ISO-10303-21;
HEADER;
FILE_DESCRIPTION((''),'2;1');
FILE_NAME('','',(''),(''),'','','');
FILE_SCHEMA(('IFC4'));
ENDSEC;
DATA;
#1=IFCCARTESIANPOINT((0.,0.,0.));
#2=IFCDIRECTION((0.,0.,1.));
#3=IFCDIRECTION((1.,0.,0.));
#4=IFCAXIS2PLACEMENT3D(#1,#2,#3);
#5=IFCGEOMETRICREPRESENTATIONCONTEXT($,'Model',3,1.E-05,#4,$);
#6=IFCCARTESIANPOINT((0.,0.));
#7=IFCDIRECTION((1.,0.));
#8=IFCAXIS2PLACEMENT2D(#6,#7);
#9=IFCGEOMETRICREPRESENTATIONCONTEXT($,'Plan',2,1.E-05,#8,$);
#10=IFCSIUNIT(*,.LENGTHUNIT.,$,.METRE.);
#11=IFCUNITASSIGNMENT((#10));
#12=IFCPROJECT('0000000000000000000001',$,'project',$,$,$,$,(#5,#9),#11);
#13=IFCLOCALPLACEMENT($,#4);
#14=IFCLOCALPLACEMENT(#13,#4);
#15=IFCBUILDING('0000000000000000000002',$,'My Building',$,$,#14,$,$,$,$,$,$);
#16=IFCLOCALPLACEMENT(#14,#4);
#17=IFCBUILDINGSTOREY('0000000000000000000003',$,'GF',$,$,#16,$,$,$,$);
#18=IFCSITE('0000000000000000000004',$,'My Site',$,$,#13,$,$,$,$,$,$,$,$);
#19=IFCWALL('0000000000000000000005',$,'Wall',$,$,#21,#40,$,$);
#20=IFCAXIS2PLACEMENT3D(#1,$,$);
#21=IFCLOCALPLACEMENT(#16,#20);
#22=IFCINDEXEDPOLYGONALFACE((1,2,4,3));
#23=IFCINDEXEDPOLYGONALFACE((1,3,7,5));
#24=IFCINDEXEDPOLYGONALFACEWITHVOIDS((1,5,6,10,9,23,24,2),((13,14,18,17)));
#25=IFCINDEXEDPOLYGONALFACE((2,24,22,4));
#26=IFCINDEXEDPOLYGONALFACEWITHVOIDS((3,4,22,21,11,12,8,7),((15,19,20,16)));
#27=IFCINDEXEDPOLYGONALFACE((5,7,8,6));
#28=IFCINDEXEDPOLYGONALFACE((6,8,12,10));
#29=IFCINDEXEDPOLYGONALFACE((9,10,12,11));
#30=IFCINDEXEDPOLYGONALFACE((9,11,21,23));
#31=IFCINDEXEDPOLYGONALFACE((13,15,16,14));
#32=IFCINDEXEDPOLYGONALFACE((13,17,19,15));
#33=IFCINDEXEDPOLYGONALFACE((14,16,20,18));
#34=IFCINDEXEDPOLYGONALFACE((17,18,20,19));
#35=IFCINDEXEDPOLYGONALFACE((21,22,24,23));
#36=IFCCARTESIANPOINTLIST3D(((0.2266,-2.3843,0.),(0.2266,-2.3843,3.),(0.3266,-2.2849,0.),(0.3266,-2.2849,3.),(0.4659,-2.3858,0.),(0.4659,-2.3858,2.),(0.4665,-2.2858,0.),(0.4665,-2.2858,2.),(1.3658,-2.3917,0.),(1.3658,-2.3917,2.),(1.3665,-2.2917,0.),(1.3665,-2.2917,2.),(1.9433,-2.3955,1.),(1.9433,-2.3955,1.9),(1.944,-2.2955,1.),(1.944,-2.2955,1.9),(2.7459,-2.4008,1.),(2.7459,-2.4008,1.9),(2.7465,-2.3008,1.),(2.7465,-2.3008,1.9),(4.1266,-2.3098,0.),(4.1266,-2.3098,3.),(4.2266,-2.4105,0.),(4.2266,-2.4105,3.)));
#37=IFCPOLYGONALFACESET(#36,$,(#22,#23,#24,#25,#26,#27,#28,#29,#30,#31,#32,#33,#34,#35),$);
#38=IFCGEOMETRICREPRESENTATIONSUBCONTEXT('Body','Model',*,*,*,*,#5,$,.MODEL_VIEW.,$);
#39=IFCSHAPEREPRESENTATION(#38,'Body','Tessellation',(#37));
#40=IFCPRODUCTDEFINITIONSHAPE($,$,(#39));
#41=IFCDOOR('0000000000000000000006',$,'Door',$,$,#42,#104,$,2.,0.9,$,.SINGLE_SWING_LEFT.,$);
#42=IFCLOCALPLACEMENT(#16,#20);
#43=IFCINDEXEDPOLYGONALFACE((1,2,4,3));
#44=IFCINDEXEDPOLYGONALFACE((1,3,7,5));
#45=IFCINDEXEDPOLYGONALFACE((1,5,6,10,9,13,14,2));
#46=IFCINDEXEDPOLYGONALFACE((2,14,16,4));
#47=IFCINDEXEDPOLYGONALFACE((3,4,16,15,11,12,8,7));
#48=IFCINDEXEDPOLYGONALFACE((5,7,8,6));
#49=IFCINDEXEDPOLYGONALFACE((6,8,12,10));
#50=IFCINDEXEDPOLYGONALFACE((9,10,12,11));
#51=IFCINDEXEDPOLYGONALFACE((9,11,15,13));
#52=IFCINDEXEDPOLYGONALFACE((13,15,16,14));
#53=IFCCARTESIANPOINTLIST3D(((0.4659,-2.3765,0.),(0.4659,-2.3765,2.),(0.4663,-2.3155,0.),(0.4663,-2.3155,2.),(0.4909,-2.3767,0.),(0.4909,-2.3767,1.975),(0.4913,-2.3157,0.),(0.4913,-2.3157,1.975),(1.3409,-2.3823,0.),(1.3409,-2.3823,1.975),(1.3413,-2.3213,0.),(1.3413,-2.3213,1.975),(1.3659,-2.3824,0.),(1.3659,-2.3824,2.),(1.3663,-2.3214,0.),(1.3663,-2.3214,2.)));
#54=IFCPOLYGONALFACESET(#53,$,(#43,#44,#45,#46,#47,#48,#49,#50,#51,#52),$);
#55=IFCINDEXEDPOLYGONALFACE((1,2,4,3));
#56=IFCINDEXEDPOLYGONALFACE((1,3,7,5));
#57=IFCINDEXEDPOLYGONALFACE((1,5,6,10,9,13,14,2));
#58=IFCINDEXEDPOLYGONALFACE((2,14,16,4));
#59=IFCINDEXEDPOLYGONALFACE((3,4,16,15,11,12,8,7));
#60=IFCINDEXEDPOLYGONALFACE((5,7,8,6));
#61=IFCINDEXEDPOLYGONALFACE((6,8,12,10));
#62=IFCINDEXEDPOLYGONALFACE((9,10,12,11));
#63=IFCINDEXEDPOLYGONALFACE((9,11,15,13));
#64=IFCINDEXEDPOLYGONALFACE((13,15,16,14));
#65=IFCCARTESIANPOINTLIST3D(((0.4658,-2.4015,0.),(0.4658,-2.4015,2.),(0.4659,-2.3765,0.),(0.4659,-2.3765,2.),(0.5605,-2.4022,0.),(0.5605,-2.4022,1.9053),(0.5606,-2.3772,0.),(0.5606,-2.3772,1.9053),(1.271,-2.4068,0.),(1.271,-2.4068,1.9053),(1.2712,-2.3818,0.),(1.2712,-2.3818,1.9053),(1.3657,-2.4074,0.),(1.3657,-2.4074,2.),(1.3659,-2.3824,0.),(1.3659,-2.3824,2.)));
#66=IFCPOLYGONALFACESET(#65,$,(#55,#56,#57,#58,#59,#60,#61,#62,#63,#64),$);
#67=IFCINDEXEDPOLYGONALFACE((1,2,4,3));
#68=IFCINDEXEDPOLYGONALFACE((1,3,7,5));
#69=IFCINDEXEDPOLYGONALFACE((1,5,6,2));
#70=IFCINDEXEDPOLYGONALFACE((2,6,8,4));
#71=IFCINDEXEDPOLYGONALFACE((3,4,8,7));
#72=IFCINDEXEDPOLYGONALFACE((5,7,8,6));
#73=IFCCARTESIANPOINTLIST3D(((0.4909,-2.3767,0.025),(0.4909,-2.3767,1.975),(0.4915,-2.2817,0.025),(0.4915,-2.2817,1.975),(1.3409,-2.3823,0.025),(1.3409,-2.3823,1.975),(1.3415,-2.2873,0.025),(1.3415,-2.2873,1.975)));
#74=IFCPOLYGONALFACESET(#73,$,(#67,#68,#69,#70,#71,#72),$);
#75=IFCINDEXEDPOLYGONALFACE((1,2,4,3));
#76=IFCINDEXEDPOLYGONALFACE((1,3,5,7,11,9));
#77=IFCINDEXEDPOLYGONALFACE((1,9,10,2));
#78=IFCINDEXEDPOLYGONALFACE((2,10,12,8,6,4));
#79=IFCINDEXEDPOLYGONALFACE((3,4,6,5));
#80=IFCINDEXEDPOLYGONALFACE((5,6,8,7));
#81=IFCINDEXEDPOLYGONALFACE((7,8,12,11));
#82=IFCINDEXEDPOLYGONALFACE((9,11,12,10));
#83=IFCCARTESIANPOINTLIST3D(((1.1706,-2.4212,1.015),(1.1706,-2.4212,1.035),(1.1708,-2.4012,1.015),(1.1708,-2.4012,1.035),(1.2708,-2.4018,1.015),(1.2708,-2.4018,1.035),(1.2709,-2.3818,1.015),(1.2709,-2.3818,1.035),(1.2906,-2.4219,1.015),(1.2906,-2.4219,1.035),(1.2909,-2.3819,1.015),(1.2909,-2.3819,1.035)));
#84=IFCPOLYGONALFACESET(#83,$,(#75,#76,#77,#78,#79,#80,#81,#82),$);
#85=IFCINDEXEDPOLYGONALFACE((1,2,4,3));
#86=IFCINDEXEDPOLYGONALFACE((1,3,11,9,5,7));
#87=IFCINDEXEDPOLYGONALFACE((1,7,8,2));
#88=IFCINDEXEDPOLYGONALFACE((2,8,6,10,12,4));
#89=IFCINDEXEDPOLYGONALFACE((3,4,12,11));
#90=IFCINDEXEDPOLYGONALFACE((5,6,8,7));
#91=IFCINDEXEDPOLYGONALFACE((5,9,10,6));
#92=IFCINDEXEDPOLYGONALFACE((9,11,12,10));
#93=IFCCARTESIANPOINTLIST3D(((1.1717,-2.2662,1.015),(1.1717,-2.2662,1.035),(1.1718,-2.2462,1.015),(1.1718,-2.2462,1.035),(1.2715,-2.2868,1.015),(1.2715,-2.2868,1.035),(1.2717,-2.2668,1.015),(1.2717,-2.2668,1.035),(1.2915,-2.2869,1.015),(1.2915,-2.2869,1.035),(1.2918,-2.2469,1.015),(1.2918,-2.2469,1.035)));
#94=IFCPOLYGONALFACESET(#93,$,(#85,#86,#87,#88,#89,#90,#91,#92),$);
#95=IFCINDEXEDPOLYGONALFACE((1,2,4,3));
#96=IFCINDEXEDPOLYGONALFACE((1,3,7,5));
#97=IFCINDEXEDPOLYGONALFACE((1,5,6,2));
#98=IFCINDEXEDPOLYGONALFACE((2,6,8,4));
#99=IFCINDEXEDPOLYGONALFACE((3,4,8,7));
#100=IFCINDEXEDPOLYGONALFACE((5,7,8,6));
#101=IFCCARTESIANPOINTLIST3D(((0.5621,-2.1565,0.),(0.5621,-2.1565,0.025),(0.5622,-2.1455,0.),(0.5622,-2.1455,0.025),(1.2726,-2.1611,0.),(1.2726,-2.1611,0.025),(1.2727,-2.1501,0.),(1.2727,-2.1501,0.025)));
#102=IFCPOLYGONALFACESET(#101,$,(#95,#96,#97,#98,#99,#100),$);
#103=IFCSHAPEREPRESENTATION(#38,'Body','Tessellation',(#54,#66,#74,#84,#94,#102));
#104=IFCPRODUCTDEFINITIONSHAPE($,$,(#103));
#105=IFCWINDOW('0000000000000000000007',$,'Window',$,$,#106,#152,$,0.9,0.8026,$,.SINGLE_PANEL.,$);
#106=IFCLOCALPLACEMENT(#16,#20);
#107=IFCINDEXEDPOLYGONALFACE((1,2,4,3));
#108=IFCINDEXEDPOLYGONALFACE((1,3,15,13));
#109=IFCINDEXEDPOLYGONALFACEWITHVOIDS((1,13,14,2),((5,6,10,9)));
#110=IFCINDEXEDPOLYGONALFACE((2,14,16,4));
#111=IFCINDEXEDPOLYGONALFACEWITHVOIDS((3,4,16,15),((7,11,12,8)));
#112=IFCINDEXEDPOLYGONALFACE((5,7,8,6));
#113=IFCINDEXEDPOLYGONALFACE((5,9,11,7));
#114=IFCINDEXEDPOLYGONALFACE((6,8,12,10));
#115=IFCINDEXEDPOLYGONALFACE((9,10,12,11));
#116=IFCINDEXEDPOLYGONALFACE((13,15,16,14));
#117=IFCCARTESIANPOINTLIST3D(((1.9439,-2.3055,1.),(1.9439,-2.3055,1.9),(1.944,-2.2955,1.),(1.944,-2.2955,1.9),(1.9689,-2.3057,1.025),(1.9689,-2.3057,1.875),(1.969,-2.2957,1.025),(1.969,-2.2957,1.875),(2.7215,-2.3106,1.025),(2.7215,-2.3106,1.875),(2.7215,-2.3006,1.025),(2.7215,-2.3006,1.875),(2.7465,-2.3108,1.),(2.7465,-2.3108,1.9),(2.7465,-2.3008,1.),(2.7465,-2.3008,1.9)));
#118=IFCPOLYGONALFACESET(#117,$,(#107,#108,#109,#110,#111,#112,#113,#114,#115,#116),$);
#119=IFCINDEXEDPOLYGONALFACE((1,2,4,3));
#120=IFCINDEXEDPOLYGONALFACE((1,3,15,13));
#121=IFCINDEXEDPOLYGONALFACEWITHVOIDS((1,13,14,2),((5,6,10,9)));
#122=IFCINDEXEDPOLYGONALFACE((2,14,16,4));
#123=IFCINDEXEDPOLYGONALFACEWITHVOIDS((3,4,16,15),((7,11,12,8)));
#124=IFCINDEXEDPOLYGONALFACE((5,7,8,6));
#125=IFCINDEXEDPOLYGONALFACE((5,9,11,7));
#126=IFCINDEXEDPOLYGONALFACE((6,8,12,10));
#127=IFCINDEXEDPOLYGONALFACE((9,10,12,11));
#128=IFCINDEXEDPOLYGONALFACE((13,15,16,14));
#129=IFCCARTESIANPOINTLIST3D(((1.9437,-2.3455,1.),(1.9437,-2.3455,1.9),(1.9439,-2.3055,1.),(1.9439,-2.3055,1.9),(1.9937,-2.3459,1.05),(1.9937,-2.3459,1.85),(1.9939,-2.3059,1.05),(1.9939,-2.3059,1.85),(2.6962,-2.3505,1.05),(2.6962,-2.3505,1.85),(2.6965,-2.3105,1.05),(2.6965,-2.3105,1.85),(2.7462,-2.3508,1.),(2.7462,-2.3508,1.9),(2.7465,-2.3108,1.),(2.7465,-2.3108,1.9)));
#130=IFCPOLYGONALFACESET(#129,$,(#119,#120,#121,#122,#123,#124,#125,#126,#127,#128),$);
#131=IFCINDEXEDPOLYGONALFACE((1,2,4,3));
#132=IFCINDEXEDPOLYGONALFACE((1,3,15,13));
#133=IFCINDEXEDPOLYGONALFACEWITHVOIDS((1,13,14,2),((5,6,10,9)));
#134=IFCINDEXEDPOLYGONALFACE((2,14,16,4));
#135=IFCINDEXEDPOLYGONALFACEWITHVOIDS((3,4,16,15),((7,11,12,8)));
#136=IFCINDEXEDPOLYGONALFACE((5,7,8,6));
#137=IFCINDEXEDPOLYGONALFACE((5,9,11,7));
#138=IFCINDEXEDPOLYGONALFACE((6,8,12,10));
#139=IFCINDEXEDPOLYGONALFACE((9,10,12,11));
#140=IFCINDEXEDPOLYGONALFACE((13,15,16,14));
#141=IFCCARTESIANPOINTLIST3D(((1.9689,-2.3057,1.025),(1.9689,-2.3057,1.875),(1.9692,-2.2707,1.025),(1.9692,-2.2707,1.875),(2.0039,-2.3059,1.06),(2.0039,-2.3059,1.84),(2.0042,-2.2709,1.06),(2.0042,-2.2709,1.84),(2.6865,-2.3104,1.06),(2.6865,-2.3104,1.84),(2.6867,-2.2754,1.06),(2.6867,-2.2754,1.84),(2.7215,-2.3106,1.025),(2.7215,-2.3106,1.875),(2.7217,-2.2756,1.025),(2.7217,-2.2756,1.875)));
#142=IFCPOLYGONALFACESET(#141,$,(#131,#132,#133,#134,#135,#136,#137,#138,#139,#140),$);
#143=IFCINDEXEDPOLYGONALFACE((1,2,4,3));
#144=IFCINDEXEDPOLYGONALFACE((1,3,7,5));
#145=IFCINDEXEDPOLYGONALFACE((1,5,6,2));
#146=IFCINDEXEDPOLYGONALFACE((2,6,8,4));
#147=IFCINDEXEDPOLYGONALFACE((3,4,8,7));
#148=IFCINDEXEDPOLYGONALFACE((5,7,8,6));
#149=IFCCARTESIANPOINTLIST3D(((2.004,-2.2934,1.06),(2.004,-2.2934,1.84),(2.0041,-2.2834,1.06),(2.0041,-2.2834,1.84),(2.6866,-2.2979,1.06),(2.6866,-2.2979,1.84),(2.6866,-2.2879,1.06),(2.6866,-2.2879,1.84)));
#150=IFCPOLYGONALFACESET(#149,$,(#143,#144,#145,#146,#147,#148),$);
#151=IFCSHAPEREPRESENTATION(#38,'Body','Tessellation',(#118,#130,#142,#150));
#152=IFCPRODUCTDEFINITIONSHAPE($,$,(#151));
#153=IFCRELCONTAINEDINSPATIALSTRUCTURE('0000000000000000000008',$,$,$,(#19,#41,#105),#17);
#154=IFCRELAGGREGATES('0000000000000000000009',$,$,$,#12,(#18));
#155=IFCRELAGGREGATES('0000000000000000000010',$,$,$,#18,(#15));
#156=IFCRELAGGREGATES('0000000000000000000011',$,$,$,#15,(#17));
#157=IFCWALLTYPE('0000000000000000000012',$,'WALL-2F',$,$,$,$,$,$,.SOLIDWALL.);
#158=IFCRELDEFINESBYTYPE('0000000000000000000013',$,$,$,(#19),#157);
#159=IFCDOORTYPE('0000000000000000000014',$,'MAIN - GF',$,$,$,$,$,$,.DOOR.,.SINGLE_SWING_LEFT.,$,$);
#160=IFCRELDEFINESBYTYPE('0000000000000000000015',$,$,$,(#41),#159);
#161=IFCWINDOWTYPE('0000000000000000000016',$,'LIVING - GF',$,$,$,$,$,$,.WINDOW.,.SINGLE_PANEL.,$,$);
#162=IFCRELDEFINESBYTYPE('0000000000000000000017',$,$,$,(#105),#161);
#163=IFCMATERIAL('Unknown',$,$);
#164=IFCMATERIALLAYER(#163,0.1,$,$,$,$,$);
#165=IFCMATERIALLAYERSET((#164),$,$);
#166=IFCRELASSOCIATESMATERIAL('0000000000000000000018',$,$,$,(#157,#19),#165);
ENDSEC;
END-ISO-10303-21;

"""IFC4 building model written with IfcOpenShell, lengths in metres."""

from ifc_helpers import new_model, entity, si_unit, frame, origin_with_axes, origin_2d_with_axis, place, context, subcontext, project, spatial, line, indexed_curve, outline, extrude, shape, source, transform, mapped, material, layer, layer_set, layer_usage, type_object, type_shapes, element, fill, save


model = new_model("IFC4")

# Units and contexts
model_context = context("Model", 3, precision=1e-05, world=origin_with_axes())
plan_context = context("Plan", 2, precision=1e-05, world=origin_2d_with_axis())
body_context_1 = subcontext(model_context, "Body", "Model", "MODEL_VIEW")
body_context_2 = subcontext(plan_context, "Body", "Plan", "PLAN_VIEW")
ifc_project = project(units=[si_unit("LENGTHUNIT", "METRE")], contexts=[model_context, plan_context])

# Site, building, storey
site_placement = place(None, origin_with_axes())
site = spatial("IfcSite", under=ifc_project, at=site_placement, Name="My Site")
building_placement = place(site_placement, origin_with_axes())
building = spatial("IfcBuilding", under=site, at=building_placement, Name="My Building")
storey_placement = place(building_placement, origin_with_axes())
storey = spatial("IfcBuildingStorey", under=building, at=storey_placement, Name="GF")

# Shared definitions
ifc_material_1 = material(Name="Unknown")

# Shared definitions
ifc_layer_1 = layer(ifc_material_1, 0.1)
ifc_layer_set_1 = layer_set([ifc_layer_1])
wall_type_1 = type_object("IfcWallType", Name="WALL-2F", PredefinedType="SOLIDWALL", material=ifc_layer_set_1)

# Wall, openings, door, window
ifc_layer_usage_1 = layer_usage(ifc_layer_set_1, "AXIS2", "POSITIVE", 0.0)
wall_1_placement = place(storey_placement, frame((0.2266, -2.3843, 0.0), z_axis=(0.0, 0.0, 1.0), x_axis=(0.999979, -0.006552, 0.0)))
wall_1 = element("IfcWall", 1, at=wall_1_placement, inside=storey, type_object=wall_type_1, material=ifc_layer_usage_1, Name="Wall", context=body_context_1, shape_type="SweptSolid", body=[
    extrude(outline(indexed_curve([(0.0, 0.0), (0.0993, 0.1), (3.8994, 0.1), (4.0001, 0.0)], segments=[line(1, 2, 3, 4, 1)])), origin_with_axes(), (0.0, 0.0, 1.0), 3.0),
])
shared_shape_1 = source(origin_with_axes(), body_context_1, "Body", "SweptSolid", [
    extrude(outline(indexed_curve([(0.0, 0.0), (0.9, 0.0), (0.9, 2.0), (0.0, 2.0)], segments=[line(1, 2, 3, 4, 1)])), frame((0.0, -0.6, 0.0), z_axis=(0.0, -1.0, 0.0), x_axis=(1.0, 0.0, 0.0)), (0.0, 0.0, -1.0), 1.2),
])
opening_1_placement = place(wall_1_placement, frame((0.2393, 0.0, 0.0), z_axis=(0.0, 0.0, 1.0), x_axis=(1.0, 0.0, 0.0)))
opening_1 = element("IfcOpeningElement", 2, at=opening_1_placement, cuts=wall_1, PredefinedType="OPENING", context=body_context_1, shape_type="MappedRepresentation", body=[
    mapped(shared_shape_1, transform((0.0, 0.0, 0.0), x_axis=(1.0, 0.0, 0.0), y_axis=(0.0, 1.0, 0.0), z_axis=(0.0, 0.0, 1.0), scale=1.0)),
])
shared_shape_2 = source(origin_with_axes(), body_context_1, "Body", "SweptSolid", [
    extrude(outline(indexed_curve([(0.0, 0.0), (0.8026, 0.0), (0.8026, 0.9), (0.0, 0.9)], segments=[line(1, 2, 3, 4, 1)])), frame((0.0, -0.6, 0.0), z_axis=(0.0, -1.0, 0.0), x_axis=(1.0, 0.0, 0.0)), (0.0, 0.0, -1.0), 1.2),
])
opening_2_placement = place(wall_1_placement, frame((1.7168, 0.0, 1.0), z_axis=(0.0, 0.0, 1.0), x_axis=(1.0, 0.0, 0.0)))
opening_2 = element("IfcOpeningElement", 3, at=opening_2_placement, cuts=wall_1, PredefinedType="OPENING", context=body_context_1, shape_type="MappedRepresentation", body=[
    mapped(shared_shape_2, transform((0.0, 0.0, 0.0), x_axis=(1.0, 0.0, 0.0), y_axis=(0.0, 1.0, 0.0), z_axis=(0.0, 0.0, 1.0), scale=1.0)),
])
door_type_1 = type_object("IfcDoorType", Name="MAIN - GF", OperationType="SINGLE_SWING_LEFT", PredefinedType="DOOR")
shared_shape_3 = source(origin_with_axes(), body_context_1, "Body", "SweptSolid", [
    extrude(outline(indexed_curve([(0.0, 0.0), (0.0, 2.0), (0.9, 2.0), (0.9, 0.0), (0.875, 0.0), (0.875, 1.975), (0.025, 1.975), (0.025, 0.0)], segments=[line(1, 2, 3, 4, 5, 6, 7, 8, 1)])), frame((0.0, 0.0093, 0.0), z_axis=(0.0, -1.0, 0.0), x_axis=(1.0, 0.0, 0.0)), (0.0, 0.0, -1.0), 0.061),
    extrude(outline(indexed_curve([(0.0, 0.0), (0.0, 2.0), (0.9, 2.0), (0.9, 0.0), (0.8053, 0.0), (0.8053, 1.9053), (0.0947, 1.9053), (0.0947, 0.0)], segments=[line(1, 2, 3, 4, 5, 6, 7, 8, 1)])), frame((0.0, -0.0157, 0.0), z_axis=(0.0, -1.0, 0.0), x_axis=(1.0, 0.0, 0.0)), (0.0, 0.0, -1.0), 0.025),
    extrude(outline(indexed_curve([(0.0, 0.0), (0.85, 0.0), (0.85, 0.095), (0.0, 0.095)], segments=[line(1, 2, 3, 4, 1)])), frame((0.025, 0.0093, 0.025), z_axis=(0.0, 0.0, 1.0), x_axis=(1.0, 0.0, 0.0)), (0.0, 0.0, 1.0), 1.95),
    extrude(outline(indexed_curve([(0.0, 0.0), (0.0, -0.04), (-0.12, -0.04), (-0.12, -0.02), (-0.02, -0.02), (-0.02, 0.0)], segments=[line(1, 2, 3, 4, 5, 6, 1)])), frame((0.825, 0.0093, 1.015), z_axis=(0.0, 0.0, 1.0), x_axis=(1.0, 0.0, 0.0)), (0.0, 0.0, 1.0), 0.02),
    extrude(outline(indexed_curve([(0.0, 0.0), (0.0, 0.04), (-0.12, 0.04), (-0.12, 0.02), (-0.02, 0.02), (-0.02, 0.0)], segments=[line(1, 2, 3, 4, 5, 6, 1)])), frame((0.825, 0.1043, 1.015), z_axis=(0.0, 0.0, 1.0), x_axis=(1.0, 0.0, 0.0)), (0.0, 0.0, 1.0), 0.02),
    extrude(outline(indexed_curve([(0.0, 0.0), (0.7105, 0.0), (0.7105, 0.011), (0.0, 0.011)], segments=[line(1, 2, 3, 4, 1)])), frame((0.0947, 0.23, 0.0), z_axis=(0.0, 0.0, 1.0), x_axis=(1.0, 0.0, 0.0)), (0.0, 0.0, 1.0), 0.025),
])
shared_shape_4 = source(origin_with_axes(), body_context_2, "Body", "Curve2D", [
    entity("IfcIndexedPolyCurve", entity("IfcCartesianPointList2D", [[0.0, -0.0157], [0.0, 0.0703], [0.025, 0.0703], [0.025, 0.0093], [0.0947, 0.0093], [0.0947, -0.0157]]), [entity("IfcLineIndex", [1, 2, 3, 4, 5, 6, 1])]),
    entity("IfcIndexedPolyCurve", entity("IfcCartesianPointList2D", [[0.9, -0.0157], [0.9, 0.0703], [0.875, 0.0703], [0.875, 0.0093], [0.8053, 0.0093], [0.8053, -0.0157]]), [entity("IfcLineIndex", [1, 2, 3, 4, 5, 6, 1])]),
    entity("IfcTrimmedCurve", entity("IfcEllipse", entity("IfcAxis2Placement2D", entity("IfcCartesianPoint", [0.12, 0.0703]), entity("IfcDirection", [1.0, 0.0])), 0.755, 0.85), [entity("IfcCartesianPoint", [0.875, 0.0703])], [entity("IfcCartesianPoint", [0.12, 0.9203])], True, "CARTESIAN"),
    entity("IfcIndexedPolyCurve", entity("IfcCartesianPointList2D", [[0.025, 0.0703], [0.12, 0.0703], [0.12, 0.9203], [0.025, 0.9203]]), [entity("IfcLineIndex", [1, 2, 3, 4, 1])]),
])
type_shapes(door_type_1, [shared_shape_3, shared_shape_4])
door_1_placement = place(opening_1_placement, frame((0.0, 0.0, 0.0), z_axis=(0.0, 0.0, 1.0), x_axis=(1.0, 0.0, 0.0)))
door_1 = element("IfcDoor", 4, at=door_1_placement, inside=storey, type_object=door_type_1, Name="Door", OperationType="SINGLE_SWING_LEFT", OverallHeight=2.0, OverallWidth=0.9, shapes=[
    shape(body_context_1, "Body", "MappedRepresentation", [mapped(shared_shape_3, transform((0.0, 0.0, 0.0), x_axis=(1.0, 0.0, 0.0), y_axis=(0.0, 1.0, 0.0), z_axis=(0.0, 0.0, 1.0), scale=1.0))]),
    shape(body_context_2, "Body", "MappedRepresentation", [mapped(shared_shape_4, transform((0.0, 0.0, 0.0), x_axis=(1.0, 0.0, 0.0), y_axis=(0.0, 1.0, 0.0), z_axis=(0.0, 0.0, 1.0), scale=1.0))]),
])
fill(opening_1, door_1)
window_type_1 = type_object("IfcWindowType", Name="LIVING - GF", PartitioningType="SINGLE_PANEL", PredefinedType="WINDOW")
shared_shape_5 = source(origin_with_axes(), body_context_1, "Body", "SweptSolid", [
    extrude(outline(indexed_curve([(0.0, 0.0), (0.8026, 0.0), (0.8026, 0.9), (0.0, 0.9)], segments=[line(1, 2, 3, 4, 1)]), holes=[indexed_curve([(0.025, 0.025), (0.7776, 0.025), (0.7776, 0.875), (0.025, 0.875)], segments=[line(1, 2, 3, 4, 1)])]), frame((0.0, 0.09, 0.0), z_axis=(0.0, -1.0, 0.0), x_axis=(1.0, 0.0, 0.0)), (0.0, 0.0, -1.0), 0.01),
    extrude(outline(indexed_curve([(0.0, 0.0), (0.8026, 0.0), (0.8026, 0.9), (0.0, 0.9)], segments=[line(1, 2, 3, 4, 1)]), holes=[indexed_curve([(0.05, 0.05), (0.7526, 0.05), (0.7526, 0.85), (0.05, 0.85)], segments=[line(1, 2, 3, 4, 1)])]), frame((0.0, 0.05, 0.0), z_axis=(0.0, -1.0, 0.0), x_axis=(1.0, 0.0, 0.0)), (0.0, 0.0, -1.0), 0.04),
    extrude(outline(indexed_curve([(0.0, 0.0), (0.7526, 0.0), (0.7526, 0.85), (0.0, 0.85)], segments=[line(1, 2, 3, 4, 1)]), holes=[indexed_curve([(0.035, 0.035), (0.7176, 0.035), (0.7176, 0.815), (0.035, 0.815)], segments=[line(1, 2, 3, 4, 1)])]), frame((0.025, 0.09, 0.025), z_axis=(0.0, -1.0, 0.0), x_axis=(1.0, 0.0, 0.0)), (0.0, 0.0, -1.0), 0.035),
    extrude(outline(indexed_curve([(0.035, 0.035), (0.7176, 0.035), (0.7176, 0.815), (0.035, 0.815)], segments=[line(1, 2, 3, 4, 1)])), frame((0.025, 0.1025, 0.025), z_axis=(0.0, -1.0, 0.0), x_axis=(1.0, 0.0, 0.0)), (0.0, 0.0, -1.0), 0.01),
])
shared_shape_6 = source(origin_with_axes(), body_context_2, "Body", "Curve2D", [
    entity("IfcIndexedPolyCurve", entity("IfcCartesianPointList2D", [[0.05, 0.05], [0.7526, 0.05]])),
    entity("IfcIndexedPolyCurve", entity("IfcCartesianPointList2D", [[0.0, 0.1], [0.025, 0.1], [0.025, 0.09], [0.05, 0.09], [0.05, 0.05], [0.0, 0.05]]), [entity("IfcLineIndex", [1, 2, 3, 4, 5, 6, 1])]),
    entity("IfcIndexedPolyCurve", entity("IfcCartesianPointList2D", [[0.8026, 0.1], [0.7776, 0.1], [0.7776, 0.09], [0.7526, 0.09], [0.7526, 0.05], [0.8026, 0.05]]), [entity("IfcLineIndex", [1, 2, 3, 4, 5, 6, 1])]),
    entity("IfcIndexedPolyCurve", entity("IfcCartesianPointList2D", [[0.025, 0.09], [0.06, 0.09], [0.06, 0.125], [0.025, 0.125]]), [entity("IfcLineIndex", [1, 2, 3, 4, 1])]),
    entity("IfcIndexedPolyCurve", entity("IfcCartesianPointList2D", [[0.7776, 0.09], [0.7426, 0.09], [0.7426, 0.125], [0.7776, 0.125]]), [entity("IfcLineIndex", [1, 2, 3, 4, 1])]),
    entity("IfcIndexedPolyCurve", entity("IfcCartesianPointList2D", [[0.06, 0.09], [0.7426, 0.09]])),
    entity("IfcIndexedPolyCurve", entity("IfcCartesianPointList2D", [[0.06, 0.125], [0.7426, 0.125]])),
    entity("IfcIndexedPolyCurve", entity("IfcCartesianPointList2D", [[0.06, 0.1075], [0.7426, 0.1075]])),
])
type_shapes(window_type_1, [shared_shape_5, shared_shape_6])
window_1_placement = place(opening_2_placement, frame((0.0, 0.0, 0.0), z_axis=(0.0, 0.0, 1.0), x_axis=(1.0, 0.0, 0.0)))
window_1 = element("IfcWindow", 5, at=window_1_placement, inside=storey, type_object=window_type_1, Name="Window", OverallHeight=0.9, OverallWidth=0.8026, PartitioningType="SINGLE_PANEL", shapes=[
    shape(body_context_1, "Body", "MappedRepresentation", [mapped(shared_shape_5, transform((0.0, 0.0, 0.0), x_axis=(1.0, 0.0, 0.0), y_axis=(0.0, 1.0, 0.0), z_axis=(0.0, 0.0, 1.0), scale=1.0))]),
    shape(body_context_2, "Body", "MappedRepresentation", [mapped(shared_shape_6, transform((0.0, 0.0, 0.0), x_axis=(1.0, 0.0, 0.0), y_axis=(0.0, 1.0, 0.0), z_axis=(0.0, 0.0, 1.0), scale=1.0))]),
])
fill(opening_2, window_1)

save(model, "model.ifc")
